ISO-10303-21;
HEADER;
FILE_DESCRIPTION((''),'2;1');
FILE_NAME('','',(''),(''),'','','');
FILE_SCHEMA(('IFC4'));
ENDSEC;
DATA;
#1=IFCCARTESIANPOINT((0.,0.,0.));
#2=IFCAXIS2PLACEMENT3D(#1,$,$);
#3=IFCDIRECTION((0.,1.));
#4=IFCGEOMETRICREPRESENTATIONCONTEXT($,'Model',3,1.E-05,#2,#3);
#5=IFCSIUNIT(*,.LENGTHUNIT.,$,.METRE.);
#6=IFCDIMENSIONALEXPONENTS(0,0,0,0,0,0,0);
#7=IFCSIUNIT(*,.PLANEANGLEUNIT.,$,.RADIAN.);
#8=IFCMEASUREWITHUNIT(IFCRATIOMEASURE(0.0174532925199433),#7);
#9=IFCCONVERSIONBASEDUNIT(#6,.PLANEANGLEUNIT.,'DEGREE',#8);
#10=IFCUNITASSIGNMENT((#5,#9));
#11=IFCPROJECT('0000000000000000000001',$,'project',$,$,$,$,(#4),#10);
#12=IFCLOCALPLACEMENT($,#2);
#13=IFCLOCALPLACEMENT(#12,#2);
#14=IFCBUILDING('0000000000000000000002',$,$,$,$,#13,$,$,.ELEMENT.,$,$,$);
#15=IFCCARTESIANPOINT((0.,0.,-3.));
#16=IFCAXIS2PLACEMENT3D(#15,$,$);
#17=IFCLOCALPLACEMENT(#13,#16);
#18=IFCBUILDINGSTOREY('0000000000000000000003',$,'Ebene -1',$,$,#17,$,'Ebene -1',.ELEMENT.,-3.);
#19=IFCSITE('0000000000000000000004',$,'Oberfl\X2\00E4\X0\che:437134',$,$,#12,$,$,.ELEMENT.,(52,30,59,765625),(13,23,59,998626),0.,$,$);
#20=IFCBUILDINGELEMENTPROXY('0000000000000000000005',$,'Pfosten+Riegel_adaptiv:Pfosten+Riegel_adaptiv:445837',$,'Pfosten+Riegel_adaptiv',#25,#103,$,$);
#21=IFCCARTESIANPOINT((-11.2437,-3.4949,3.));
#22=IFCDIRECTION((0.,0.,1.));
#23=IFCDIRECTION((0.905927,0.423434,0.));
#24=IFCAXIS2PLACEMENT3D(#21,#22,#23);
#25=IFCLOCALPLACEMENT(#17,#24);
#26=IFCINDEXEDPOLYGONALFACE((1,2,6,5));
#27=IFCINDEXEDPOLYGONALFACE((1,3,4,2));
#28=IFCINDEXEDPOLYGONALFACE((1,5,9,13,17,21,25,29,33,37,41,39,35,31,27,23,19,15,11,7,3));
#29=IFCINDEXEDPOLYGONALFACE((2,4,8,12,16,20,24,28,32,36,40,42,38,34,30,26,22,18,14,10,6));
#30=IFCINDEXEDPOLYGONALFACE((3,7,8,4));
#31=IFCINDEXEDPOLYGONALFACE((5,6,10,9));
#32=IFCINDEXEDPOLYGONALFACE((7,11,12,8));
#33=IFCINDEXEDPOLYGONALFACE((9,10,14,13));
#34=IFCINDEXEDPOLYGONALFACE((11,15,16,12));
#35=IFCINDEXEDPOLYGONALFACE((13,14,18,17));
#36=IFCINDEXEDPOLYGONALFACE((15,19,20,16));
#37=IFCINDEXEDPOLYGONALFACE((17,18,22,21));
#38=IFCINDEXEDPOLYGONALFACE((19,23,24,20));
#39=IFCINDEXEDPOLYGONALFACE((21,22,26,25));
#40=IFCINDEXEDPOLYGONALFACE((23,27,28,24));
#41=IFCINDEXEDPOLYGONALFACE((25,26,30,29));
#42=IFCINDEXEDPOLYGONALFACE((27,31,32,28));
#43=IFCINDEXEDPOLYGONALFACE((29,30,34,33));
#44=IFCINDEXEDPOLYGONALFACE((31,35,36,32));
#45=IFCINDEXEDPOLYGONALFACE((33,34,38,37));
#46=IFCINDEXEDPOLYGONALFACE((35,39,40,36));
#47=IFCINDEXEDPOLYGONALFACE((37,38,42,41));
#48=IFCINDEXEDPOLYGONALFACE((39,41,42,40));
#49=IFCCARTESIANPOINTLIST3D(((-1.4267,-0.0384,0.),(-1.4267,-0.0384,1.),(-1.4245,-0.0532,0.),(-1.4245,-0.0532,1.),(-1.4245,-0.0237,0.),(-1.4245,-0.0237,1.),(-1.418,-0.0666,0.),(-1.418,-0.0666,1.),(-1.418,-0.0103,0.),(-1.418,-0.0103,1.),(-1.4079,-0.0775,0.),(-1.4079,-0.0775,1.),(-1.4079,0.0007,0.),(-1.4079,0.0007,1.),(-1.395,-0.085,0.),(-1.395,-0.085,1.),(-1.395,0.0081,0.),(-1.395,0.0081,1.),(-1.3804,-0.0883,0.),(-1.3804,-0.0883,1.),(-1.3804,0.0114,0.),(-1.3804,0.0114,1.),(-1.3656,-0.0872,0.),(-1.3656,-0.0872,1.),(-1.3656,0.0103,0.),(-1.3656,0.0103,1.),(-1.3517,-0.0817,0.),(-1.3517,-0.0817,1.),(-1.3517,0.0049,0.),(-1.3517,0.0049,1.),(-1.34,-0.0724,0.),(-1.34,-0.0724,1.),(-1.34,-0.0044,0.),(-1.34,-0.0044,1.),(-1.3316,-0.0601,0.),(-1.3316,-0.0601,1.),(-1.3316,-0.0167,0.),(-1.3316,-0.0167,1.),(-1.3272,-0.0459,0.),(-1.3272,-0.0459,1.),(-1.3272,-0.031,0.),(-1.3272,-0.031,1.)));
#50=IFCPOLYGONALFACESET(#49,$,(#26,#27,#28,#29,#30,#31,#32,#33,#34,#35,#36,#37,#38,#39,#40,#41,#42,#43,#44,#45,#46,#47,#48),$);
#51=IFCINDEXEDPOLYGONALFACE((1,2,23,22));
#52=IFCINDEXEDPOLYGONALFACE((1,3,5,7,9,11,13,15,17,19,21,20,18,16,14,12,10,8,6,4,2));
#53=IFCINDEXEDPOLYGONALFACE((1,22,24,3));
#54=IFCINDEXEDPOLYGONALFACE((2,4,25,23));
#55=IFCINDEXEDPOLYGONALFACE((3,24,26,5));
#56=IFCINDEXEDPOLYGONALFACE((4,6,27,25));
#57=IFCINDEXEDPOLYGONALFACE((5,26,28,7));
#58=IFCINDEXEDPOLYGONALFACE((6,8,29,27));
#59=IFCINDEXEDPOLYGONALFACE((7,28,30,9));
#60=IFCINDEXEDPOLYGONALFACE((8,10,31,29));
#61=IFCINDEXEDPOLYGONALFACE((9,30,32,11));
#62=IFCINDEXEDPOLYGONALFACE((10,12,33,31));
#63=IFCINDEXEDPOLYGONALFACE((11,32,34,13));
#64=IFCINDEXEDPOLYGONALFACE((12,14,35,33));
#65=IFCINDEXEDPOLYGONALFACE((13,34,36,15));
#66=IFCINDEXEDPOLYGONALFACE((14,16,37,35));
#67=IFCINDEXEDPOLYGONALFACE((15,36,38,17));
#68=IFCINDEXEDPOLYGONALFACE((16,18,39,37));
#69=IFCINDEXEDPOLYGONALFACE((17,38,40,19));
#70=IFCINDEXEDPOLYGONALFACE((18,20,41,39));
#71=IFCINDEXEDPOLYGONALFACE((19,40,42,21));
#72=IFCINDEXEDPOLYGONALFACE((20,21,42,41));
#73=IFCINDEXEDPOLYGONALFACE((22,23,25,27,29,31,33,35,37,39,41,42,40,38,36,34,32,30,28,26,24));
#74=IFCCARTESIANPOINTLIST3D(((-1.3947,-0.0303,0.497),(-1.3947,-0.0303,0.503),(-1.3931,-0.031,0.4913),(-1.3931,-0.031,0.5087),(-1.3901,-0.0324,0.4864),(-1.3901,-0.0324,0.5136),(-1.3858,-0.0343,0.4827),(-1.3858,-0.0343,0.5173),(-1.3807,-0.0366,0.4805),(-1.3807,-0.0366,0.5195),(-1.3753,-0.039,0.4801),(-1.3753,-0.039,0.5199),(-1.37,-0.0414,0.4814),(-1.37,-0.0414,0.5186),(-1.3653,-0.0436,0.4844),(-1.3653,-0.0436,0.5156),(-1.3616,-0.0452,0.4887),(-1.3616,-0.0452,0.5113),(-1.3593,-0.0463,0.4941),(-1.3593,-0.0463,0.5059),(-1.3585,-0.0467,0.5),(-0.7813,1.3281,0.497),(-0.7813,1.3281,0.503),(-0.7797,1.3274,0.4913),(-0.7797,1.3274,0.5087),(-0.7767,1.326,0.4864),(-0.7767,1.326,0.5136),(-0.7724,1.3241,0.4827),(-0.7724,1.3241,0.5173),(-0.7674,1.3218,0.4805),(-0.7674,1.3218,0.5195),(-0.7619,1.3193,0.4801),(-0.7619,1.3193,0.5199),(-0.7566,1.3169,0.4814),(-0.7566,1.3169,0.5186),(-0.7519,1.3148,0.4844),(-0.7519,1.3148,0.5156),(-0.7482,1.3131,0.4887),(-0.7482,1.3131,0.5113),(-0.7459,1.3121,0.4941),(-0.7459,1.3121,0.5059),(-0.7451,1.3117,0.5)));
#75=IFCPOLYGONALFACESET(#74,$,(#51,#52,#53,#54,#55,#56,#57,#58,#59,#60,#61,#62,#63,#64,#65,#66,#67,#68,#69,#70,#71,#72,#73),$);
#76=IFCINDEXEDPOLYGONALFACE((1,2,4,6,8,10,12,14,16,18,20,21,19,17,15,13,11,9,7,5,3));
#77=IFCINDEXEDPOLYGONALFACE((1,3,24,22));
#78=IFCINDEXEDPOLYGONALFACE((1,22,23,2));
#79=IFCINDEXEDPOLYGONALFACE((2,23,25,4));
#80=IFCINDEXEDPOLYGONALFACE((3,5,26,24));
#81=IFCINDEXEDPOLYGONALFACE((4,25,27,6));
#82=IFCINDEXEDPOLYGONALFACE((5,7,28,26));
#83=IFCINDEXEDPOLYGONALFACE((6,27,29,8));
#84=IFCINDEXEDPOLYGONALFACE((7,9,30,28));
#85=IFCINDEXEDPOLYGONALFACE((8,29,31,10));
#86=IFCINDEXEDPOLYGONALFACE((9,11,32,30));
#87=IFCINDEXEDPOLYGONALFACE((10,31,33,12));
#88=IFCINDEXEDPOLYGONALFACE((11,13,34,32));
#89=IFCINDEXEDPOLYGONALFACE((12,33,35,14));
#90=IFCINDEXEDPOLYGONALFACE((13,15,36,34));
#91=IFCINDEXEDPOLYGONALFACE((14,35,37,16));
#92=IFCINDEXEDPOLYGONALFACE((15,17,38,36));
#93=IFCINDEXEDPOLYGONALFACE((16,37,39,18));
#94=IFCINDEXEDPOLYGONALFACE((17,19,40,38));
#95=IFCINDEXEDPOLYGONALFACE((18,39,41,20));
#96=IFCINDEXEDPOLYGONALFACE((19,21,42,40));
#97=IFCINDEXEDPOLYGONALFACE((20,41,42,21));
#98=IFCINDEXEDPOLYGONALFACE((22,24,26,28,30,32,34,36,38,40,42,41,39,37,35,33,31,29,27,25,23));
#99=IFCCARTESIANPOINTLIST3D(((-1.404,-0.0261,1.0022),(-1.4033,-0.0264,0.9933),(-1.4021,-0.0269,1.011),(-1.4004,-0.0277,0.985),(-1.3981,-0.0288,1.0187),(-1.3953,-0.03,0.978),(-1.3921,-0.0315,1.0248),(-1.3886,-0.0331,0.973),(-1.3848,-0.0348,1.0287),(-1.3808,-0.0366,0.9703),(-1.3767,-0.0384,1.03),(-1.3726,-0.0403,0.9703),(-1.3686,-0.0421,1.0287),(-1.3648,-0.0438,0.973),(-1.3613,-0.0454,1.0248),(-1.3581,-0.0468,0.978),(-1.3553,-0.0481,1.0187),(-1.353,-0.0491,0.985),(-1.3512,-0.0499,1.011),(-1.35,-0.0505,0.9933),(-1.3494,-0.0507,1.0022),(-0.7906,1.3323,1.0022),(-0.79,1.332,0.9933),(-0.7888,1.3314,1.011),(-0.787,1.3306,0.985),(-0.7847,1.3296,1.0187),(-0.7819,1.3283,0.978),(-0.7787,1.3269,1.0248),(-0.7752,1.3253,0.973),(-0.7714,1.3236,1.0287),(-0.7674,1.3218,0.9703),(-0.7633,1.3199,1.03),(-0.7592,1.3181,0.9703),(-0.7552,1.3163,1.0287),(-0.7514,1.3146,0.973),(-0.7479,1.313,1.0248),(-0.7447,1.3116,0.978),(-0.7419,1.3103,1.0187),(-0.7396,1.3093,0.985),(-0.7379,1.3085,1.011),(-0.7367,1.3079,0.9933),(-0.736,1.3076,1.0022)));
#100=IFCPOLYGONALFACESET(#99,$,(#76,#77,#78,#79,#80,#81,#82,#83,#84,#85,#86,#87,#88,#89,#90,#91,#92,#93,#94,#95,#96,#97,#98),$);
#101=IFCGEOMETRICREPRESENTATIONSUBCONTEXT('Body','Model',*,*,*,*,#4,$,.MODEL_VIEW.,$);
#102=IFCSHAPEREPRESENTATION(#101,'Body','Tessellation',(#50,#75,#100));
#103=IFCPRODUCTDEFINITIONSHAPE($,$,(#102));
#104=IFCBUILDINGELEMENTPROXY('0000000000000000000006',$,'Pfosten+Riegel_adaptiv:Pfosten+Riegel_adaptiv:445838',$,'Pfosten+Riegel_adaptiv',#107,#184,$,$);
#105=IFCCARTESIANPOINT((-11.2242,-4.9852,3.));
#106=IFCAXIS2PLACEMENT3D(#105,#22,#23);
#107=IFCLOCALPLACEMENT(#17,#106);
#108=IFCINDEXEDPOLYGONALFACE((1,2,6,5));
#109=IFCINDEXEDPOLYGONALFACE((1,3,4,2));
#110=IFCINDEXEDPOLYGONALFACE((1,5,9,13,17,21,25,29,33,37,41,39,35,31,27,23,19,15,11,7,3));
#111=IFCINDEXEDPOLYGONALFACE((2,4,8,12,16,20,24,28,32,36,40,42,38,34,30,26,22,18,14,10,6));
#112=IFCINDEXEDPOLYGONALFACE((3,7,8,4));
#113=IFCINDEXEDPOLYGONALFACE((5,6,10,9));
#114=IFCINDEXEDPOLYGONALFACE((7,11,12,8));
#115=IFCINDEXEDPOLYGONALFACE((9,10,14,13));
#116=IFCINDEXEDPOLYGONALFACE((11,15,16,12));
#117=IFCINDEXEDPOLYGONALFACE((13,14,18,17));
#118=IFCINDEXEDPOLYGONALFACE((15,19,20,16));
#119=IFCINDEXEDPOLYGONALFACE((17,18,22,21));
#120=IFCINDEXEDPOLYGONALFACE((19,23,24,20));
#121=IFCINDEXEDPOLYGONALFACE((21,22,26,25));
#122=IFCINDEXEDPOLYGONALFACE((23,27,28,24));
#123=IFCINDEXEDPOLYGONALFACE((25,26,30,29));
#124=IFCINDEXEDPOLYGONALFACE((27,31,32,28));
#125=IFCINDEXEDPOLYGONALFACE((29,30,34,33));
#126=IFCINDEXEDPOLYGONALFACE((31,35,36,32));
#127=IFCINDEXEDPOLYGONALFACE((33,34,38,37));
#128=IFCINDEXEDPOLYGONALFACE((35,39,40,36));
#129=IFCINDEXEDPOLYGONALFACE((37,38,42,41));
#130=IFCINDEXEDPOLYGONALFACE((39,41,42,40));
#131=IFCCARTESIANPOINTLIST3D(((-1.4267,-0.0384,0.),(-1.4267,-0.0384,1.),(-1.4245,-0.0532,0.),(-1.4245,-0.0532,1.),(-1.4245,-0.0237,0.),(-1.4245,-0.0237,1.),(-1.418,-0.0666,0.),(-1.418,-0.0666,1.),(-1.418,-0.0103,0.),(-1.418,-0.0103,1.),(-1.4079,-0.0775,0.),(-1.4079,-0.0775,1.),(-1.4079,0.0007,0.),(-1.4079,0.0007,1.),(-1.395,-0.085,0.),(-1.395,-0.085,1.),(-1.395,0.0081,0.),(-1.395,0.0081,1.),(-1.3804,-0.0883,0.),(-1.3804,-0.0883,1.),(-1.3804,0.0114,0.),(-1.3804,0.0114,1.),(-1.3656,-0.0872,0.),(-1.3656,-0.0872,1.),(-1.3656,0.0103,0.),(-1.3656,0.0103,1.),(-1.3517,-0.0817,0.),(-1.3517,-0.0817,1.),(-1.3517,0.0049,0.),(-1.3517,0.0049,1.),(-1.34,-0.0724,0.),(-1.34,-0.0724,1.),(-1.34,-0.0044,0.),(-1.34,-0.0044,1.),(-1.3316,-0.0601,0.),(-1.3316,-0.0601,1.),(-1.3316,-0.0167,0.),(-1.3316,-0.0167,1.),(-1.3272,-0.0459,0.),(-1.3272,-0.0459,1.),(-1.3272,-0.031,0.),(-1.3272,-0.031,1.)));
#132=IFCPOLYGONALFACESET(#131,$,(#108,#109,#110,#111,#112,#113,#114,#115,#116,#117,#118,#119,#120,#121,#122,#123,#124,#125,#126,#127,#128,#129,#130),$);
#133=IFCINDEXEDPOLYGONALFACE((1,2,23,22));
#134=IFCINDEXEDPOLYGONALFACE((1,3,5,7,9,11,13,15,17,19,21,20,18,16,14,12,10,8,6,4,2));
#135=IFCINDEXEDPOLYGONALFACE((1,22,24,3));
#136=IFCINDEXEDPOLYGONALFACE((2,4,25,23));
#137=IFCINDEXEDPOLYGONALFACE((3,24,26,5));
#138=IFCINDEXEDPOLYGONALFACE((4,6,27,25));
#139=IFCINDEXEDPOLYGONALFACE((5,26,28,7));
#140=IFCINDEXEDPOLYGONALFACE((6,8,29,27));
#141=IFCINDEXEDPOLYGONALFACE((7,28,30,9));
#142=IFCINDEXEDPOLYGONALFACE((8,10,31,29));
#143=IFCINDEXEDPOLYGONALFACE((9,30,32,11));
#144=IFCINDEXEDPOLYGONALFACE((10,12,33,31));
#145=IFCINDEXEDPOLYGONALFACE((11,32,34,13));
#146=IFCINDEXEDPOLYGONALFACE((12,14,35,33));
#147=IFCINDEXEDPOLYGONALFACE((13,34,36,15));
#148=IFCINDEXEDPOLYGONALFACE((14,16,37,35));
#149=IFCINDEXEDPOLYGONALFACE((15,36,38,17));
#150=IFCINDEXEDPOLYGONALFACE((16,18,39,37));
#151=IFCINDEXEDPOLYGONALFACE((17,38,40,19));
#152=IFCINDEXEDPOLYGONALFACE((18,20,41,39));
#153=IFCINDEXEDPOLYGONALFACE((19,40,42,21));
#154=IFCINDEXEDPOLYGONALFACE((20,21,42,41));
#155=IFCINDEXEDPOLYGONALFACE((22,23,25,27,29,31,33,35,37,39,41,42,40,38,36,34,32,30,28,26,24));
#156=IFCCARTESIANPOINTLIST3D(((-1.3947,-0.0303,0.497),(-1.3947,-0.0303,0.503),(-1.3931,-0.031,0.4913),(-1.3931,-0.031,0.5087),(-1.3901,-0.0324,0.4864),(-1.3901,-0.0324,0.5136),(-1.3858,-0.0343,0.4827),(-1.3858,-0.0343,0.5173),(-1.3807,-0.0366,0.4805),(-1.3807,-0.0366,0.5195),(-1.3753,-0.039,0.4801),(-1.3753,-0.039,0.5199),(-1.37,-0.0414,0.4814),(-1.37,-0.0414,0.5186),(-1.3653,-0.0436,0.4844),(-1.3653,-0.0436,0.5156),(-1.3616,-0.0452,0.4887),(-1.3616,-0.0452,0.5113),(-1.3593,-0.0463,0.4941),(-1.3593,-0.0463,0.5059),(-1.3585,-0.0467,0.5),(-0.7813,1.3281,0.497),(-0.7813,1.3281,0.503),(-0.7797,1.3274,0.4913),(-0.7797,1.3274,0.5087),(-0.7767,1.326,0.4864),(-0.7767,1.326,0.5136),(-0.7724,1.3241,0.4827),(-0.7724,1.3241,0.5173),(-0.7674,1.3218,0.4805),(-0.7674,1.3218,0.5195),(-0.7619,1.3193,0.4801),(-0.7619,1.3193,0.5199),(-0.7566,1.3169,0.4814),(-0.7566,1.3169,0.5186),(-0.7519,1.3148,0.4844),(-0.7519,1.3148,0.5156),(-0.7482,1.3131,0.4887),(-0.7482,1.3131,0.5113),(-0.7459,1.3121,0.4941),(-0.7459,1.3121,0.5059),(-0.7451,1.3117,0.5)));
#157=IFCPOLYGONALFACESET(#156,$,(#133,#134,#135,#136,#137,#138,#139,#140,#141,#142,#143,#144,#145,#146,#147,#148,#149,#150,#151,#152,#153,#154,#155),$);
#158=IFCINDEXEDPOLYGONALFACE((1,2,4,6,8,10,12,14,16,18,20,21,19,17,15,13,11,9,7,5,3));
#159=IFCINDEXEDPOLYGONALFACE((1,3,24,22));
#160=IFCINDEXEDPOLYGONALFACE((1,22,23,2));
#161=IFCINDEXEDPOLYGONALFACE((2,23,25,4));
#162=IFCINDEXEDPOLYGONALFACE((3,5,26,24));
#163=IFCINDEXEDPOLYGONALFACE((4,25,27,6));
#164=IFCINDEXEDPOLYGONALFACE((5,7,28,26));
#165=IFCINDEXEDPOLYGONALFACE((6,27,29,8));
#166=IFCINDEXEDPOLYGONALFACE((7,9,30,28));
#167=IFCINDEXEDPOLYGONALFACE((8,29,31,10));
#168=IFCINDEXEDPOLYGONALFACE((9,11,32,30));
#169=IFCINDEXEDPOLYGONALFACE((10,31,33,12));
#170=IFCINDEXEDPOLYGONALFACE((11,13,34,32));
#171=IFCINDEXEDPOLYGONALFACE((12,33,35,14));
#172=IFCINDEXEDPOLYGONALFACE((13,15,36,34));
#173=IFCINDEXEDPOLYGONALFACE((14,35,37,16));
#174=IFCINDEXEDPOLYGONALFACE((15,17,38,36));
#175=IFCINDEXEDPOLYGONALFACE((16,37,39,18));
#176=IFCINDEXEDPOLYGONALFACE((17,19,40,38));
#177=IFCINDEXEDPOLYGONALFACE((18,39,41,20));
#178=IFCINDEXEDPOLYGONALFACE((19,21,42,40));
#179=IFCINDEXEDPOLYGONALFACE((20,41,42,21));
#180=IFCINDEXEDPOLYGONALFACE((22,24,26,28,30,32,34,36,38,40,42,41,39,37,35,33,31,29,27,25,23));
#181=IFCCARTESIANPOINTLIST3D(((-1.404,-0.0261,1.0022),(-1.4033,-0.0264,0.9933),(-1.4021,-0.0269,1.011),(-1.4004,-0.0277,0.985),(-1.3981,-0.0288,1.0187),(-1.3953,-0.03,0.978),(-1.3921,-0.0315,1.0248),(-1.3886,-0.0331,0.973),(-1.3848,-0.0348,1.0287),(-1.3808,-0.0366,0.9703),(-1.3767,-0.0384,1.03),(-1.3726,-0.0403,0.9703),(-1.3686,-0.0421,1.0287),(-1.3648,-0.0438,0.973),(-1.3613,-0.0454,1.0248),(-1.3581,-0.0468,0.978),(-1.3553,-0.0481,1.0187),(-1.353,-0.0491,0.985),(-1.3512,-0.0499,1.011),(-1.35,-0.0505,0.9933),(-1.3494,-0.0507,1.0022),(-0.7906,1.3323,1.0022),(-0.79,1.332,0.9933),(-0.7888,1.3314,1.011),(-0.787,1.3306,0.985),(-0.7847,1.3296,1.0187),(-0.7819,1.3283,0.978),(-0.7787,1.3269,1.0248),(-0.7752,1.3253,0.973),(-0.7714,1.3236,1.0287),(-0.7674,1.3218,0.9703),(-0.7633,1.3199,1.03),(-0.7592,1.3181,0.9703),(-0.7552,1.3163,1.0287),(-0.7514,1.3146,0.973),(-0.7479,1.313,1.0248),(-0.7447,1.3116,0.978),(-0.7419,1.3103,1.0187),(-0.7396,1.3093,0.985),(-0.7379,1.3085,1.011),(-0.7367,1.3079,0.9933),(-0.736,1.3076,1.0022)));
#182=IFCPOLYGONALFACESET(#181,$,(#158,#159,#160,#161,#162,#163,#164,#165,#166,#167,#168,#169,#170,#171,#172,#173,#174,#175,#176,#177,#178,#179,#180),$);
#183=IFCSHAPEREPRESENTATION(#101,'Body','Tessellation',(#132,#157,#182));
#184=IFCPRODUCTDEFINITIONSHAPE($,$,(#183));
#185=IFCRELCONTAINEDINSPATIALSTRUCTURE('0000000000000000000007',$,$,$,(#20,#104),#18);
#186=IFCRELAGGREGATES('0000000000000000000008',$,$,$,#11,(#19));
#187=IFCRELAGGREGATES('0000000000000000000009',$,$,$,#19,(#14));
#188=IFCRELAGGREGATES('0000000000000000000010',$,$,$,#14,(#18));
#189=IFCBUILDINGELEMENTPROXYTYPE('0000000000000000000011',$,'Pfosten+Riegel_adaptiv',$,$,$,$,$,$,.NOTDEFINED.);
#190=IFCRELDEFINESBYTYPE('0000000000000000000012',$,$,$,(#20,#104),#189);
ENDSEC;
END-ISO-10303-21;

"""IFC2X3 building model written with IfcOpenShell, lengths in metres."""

from ifc_helpers import new_model, entity, si_unit, converted_unit, direction, frame, frame_2d, origin, place, context, subcontext, project, spatial, circle, extrude, source, transform, mapped, type_object, type_shapes, element, save


model = new_model("IFC2X3")

# Units and contexts
model_context = context("Model", 3, precision=1e-05, world=origin(), true_north=direction((0.0, 1.0)))
body_context = subcontext(model_context, "Body", "Model", "MODEL_VIEW")
ifc_project = project(units=[si_unit("LENGTHUNIT", "METRE"), converted_unit("PLANEANGLEUNIT", "DEGREE", entity("IfcRatioMeasure", 0.0174532925199433), si_unit("PLANEANGLEUNIT", "RADIAN"), dimensions=[0, 0, 0, 0, 0, 0, 0])], contexts=[model_context])

# Site, building, storey
site_placement = place(None, origin())
site = spatial("IfcSite", under=ifc_project, at=site_placement, Name="Oberfläche:437134", CompositionType="ELEMENT", RefLatitude=(52, 30, 59, 765625), RefLongitude=(13, 23, 59, 998626), RefElevation=0.0)
building_placement = place(site_placement, origin())
building = spatial("IfcBuilding", under=site, at=building_placement, CompositionType="ELEMENT")
storey_placement = place(building_placement, frame((0.0, 0.0, -3.0)))
storey = spatial("IfcBuildingStorey", under=building, at=storey_placement, Name="Ebene -1", LongName="Ebene -1", CompositionType="ELEMENT", Elevation=-3.0)

# Building element proxies
building_element_proxy_type_1 = type_object("IfcBuildingElementProxyType", Name="Pfosten+Riegel_adaptiv", PredefinedType="NOTDEFINED")
shared_shape_1 = source(origin(), body_context, "Body", "SweptSolid", [
    extrude(circle(Radius=0.05, at=frame_2d((0.0, 0.0), x_axis=(1.0, 0.0))), frame((-1.3767, -0.0384, 0.0), z_axis=(0.0, 0.0, 1.0), x_axis=(-1.0, 0.0, 0.0)), (0.0, 0.0, 1.0), 1.0),
    extrude(circle(Radius=0.02, at=frame_2d((0.0, 0.0), x_axis=(1.0, 0.0))), frame((-1.3767, -0.0384, 0.5), z_axis=(0.411546, 0.911389, 0.0), x_axis=(0.911389, -0.411546, 0.0)), (0.0, 0.0, 1.0), 1.4904),
    extrude(circle(Radius=0.03, at=frame_2d((0.0, 0.0), x_axis=(1.0, 0.0))), frame((-1.3767, -0.0384, 1.0), z_axis=(0.411546, 0.911389, 0.0), x_axis=(0.0, 0.0, 1.0)), (0.0, 0.0, 1.0), 1.4904),
])
type_shapes(building_element_proxy_type_1, [shared_shape_1])
for number, where, z_axis, x_axis, name in (
    (1, (-11.2437, -3.4949, 3.0), (0.0, 0.0, 1.0), (0.905927, 0.423434, 0.0), "Pfosten+Riegel_adaptiv:Pfosten+Riegel_adaptiv:445837"),
    (2, (-11.2242, -4.9852, 3.0), (0.0, 0.0, 1.0), (0.905927, 0.423434, 0.0), "Pfosten+Riegel_adaptiv:Pfosten+Riegel_adaptiv:445838"),
):
    element("IfcBuildingElementProxy", number, at=place(storey_placement, frame(where, z_axis=z_axis, x_axis=x_axis)), inside=storey, type_object=building_element_proxy_type_1, Name=name, ObjectType="Pfosten+Riegel_adaptiv", context=body_context, shape_type="MappedRepresentation", body=[
        mapped(shared_shape_1, transform((0.0, 0.0, 0.0), scale=1.0)),
    ])

save(model, "model.ifc")
